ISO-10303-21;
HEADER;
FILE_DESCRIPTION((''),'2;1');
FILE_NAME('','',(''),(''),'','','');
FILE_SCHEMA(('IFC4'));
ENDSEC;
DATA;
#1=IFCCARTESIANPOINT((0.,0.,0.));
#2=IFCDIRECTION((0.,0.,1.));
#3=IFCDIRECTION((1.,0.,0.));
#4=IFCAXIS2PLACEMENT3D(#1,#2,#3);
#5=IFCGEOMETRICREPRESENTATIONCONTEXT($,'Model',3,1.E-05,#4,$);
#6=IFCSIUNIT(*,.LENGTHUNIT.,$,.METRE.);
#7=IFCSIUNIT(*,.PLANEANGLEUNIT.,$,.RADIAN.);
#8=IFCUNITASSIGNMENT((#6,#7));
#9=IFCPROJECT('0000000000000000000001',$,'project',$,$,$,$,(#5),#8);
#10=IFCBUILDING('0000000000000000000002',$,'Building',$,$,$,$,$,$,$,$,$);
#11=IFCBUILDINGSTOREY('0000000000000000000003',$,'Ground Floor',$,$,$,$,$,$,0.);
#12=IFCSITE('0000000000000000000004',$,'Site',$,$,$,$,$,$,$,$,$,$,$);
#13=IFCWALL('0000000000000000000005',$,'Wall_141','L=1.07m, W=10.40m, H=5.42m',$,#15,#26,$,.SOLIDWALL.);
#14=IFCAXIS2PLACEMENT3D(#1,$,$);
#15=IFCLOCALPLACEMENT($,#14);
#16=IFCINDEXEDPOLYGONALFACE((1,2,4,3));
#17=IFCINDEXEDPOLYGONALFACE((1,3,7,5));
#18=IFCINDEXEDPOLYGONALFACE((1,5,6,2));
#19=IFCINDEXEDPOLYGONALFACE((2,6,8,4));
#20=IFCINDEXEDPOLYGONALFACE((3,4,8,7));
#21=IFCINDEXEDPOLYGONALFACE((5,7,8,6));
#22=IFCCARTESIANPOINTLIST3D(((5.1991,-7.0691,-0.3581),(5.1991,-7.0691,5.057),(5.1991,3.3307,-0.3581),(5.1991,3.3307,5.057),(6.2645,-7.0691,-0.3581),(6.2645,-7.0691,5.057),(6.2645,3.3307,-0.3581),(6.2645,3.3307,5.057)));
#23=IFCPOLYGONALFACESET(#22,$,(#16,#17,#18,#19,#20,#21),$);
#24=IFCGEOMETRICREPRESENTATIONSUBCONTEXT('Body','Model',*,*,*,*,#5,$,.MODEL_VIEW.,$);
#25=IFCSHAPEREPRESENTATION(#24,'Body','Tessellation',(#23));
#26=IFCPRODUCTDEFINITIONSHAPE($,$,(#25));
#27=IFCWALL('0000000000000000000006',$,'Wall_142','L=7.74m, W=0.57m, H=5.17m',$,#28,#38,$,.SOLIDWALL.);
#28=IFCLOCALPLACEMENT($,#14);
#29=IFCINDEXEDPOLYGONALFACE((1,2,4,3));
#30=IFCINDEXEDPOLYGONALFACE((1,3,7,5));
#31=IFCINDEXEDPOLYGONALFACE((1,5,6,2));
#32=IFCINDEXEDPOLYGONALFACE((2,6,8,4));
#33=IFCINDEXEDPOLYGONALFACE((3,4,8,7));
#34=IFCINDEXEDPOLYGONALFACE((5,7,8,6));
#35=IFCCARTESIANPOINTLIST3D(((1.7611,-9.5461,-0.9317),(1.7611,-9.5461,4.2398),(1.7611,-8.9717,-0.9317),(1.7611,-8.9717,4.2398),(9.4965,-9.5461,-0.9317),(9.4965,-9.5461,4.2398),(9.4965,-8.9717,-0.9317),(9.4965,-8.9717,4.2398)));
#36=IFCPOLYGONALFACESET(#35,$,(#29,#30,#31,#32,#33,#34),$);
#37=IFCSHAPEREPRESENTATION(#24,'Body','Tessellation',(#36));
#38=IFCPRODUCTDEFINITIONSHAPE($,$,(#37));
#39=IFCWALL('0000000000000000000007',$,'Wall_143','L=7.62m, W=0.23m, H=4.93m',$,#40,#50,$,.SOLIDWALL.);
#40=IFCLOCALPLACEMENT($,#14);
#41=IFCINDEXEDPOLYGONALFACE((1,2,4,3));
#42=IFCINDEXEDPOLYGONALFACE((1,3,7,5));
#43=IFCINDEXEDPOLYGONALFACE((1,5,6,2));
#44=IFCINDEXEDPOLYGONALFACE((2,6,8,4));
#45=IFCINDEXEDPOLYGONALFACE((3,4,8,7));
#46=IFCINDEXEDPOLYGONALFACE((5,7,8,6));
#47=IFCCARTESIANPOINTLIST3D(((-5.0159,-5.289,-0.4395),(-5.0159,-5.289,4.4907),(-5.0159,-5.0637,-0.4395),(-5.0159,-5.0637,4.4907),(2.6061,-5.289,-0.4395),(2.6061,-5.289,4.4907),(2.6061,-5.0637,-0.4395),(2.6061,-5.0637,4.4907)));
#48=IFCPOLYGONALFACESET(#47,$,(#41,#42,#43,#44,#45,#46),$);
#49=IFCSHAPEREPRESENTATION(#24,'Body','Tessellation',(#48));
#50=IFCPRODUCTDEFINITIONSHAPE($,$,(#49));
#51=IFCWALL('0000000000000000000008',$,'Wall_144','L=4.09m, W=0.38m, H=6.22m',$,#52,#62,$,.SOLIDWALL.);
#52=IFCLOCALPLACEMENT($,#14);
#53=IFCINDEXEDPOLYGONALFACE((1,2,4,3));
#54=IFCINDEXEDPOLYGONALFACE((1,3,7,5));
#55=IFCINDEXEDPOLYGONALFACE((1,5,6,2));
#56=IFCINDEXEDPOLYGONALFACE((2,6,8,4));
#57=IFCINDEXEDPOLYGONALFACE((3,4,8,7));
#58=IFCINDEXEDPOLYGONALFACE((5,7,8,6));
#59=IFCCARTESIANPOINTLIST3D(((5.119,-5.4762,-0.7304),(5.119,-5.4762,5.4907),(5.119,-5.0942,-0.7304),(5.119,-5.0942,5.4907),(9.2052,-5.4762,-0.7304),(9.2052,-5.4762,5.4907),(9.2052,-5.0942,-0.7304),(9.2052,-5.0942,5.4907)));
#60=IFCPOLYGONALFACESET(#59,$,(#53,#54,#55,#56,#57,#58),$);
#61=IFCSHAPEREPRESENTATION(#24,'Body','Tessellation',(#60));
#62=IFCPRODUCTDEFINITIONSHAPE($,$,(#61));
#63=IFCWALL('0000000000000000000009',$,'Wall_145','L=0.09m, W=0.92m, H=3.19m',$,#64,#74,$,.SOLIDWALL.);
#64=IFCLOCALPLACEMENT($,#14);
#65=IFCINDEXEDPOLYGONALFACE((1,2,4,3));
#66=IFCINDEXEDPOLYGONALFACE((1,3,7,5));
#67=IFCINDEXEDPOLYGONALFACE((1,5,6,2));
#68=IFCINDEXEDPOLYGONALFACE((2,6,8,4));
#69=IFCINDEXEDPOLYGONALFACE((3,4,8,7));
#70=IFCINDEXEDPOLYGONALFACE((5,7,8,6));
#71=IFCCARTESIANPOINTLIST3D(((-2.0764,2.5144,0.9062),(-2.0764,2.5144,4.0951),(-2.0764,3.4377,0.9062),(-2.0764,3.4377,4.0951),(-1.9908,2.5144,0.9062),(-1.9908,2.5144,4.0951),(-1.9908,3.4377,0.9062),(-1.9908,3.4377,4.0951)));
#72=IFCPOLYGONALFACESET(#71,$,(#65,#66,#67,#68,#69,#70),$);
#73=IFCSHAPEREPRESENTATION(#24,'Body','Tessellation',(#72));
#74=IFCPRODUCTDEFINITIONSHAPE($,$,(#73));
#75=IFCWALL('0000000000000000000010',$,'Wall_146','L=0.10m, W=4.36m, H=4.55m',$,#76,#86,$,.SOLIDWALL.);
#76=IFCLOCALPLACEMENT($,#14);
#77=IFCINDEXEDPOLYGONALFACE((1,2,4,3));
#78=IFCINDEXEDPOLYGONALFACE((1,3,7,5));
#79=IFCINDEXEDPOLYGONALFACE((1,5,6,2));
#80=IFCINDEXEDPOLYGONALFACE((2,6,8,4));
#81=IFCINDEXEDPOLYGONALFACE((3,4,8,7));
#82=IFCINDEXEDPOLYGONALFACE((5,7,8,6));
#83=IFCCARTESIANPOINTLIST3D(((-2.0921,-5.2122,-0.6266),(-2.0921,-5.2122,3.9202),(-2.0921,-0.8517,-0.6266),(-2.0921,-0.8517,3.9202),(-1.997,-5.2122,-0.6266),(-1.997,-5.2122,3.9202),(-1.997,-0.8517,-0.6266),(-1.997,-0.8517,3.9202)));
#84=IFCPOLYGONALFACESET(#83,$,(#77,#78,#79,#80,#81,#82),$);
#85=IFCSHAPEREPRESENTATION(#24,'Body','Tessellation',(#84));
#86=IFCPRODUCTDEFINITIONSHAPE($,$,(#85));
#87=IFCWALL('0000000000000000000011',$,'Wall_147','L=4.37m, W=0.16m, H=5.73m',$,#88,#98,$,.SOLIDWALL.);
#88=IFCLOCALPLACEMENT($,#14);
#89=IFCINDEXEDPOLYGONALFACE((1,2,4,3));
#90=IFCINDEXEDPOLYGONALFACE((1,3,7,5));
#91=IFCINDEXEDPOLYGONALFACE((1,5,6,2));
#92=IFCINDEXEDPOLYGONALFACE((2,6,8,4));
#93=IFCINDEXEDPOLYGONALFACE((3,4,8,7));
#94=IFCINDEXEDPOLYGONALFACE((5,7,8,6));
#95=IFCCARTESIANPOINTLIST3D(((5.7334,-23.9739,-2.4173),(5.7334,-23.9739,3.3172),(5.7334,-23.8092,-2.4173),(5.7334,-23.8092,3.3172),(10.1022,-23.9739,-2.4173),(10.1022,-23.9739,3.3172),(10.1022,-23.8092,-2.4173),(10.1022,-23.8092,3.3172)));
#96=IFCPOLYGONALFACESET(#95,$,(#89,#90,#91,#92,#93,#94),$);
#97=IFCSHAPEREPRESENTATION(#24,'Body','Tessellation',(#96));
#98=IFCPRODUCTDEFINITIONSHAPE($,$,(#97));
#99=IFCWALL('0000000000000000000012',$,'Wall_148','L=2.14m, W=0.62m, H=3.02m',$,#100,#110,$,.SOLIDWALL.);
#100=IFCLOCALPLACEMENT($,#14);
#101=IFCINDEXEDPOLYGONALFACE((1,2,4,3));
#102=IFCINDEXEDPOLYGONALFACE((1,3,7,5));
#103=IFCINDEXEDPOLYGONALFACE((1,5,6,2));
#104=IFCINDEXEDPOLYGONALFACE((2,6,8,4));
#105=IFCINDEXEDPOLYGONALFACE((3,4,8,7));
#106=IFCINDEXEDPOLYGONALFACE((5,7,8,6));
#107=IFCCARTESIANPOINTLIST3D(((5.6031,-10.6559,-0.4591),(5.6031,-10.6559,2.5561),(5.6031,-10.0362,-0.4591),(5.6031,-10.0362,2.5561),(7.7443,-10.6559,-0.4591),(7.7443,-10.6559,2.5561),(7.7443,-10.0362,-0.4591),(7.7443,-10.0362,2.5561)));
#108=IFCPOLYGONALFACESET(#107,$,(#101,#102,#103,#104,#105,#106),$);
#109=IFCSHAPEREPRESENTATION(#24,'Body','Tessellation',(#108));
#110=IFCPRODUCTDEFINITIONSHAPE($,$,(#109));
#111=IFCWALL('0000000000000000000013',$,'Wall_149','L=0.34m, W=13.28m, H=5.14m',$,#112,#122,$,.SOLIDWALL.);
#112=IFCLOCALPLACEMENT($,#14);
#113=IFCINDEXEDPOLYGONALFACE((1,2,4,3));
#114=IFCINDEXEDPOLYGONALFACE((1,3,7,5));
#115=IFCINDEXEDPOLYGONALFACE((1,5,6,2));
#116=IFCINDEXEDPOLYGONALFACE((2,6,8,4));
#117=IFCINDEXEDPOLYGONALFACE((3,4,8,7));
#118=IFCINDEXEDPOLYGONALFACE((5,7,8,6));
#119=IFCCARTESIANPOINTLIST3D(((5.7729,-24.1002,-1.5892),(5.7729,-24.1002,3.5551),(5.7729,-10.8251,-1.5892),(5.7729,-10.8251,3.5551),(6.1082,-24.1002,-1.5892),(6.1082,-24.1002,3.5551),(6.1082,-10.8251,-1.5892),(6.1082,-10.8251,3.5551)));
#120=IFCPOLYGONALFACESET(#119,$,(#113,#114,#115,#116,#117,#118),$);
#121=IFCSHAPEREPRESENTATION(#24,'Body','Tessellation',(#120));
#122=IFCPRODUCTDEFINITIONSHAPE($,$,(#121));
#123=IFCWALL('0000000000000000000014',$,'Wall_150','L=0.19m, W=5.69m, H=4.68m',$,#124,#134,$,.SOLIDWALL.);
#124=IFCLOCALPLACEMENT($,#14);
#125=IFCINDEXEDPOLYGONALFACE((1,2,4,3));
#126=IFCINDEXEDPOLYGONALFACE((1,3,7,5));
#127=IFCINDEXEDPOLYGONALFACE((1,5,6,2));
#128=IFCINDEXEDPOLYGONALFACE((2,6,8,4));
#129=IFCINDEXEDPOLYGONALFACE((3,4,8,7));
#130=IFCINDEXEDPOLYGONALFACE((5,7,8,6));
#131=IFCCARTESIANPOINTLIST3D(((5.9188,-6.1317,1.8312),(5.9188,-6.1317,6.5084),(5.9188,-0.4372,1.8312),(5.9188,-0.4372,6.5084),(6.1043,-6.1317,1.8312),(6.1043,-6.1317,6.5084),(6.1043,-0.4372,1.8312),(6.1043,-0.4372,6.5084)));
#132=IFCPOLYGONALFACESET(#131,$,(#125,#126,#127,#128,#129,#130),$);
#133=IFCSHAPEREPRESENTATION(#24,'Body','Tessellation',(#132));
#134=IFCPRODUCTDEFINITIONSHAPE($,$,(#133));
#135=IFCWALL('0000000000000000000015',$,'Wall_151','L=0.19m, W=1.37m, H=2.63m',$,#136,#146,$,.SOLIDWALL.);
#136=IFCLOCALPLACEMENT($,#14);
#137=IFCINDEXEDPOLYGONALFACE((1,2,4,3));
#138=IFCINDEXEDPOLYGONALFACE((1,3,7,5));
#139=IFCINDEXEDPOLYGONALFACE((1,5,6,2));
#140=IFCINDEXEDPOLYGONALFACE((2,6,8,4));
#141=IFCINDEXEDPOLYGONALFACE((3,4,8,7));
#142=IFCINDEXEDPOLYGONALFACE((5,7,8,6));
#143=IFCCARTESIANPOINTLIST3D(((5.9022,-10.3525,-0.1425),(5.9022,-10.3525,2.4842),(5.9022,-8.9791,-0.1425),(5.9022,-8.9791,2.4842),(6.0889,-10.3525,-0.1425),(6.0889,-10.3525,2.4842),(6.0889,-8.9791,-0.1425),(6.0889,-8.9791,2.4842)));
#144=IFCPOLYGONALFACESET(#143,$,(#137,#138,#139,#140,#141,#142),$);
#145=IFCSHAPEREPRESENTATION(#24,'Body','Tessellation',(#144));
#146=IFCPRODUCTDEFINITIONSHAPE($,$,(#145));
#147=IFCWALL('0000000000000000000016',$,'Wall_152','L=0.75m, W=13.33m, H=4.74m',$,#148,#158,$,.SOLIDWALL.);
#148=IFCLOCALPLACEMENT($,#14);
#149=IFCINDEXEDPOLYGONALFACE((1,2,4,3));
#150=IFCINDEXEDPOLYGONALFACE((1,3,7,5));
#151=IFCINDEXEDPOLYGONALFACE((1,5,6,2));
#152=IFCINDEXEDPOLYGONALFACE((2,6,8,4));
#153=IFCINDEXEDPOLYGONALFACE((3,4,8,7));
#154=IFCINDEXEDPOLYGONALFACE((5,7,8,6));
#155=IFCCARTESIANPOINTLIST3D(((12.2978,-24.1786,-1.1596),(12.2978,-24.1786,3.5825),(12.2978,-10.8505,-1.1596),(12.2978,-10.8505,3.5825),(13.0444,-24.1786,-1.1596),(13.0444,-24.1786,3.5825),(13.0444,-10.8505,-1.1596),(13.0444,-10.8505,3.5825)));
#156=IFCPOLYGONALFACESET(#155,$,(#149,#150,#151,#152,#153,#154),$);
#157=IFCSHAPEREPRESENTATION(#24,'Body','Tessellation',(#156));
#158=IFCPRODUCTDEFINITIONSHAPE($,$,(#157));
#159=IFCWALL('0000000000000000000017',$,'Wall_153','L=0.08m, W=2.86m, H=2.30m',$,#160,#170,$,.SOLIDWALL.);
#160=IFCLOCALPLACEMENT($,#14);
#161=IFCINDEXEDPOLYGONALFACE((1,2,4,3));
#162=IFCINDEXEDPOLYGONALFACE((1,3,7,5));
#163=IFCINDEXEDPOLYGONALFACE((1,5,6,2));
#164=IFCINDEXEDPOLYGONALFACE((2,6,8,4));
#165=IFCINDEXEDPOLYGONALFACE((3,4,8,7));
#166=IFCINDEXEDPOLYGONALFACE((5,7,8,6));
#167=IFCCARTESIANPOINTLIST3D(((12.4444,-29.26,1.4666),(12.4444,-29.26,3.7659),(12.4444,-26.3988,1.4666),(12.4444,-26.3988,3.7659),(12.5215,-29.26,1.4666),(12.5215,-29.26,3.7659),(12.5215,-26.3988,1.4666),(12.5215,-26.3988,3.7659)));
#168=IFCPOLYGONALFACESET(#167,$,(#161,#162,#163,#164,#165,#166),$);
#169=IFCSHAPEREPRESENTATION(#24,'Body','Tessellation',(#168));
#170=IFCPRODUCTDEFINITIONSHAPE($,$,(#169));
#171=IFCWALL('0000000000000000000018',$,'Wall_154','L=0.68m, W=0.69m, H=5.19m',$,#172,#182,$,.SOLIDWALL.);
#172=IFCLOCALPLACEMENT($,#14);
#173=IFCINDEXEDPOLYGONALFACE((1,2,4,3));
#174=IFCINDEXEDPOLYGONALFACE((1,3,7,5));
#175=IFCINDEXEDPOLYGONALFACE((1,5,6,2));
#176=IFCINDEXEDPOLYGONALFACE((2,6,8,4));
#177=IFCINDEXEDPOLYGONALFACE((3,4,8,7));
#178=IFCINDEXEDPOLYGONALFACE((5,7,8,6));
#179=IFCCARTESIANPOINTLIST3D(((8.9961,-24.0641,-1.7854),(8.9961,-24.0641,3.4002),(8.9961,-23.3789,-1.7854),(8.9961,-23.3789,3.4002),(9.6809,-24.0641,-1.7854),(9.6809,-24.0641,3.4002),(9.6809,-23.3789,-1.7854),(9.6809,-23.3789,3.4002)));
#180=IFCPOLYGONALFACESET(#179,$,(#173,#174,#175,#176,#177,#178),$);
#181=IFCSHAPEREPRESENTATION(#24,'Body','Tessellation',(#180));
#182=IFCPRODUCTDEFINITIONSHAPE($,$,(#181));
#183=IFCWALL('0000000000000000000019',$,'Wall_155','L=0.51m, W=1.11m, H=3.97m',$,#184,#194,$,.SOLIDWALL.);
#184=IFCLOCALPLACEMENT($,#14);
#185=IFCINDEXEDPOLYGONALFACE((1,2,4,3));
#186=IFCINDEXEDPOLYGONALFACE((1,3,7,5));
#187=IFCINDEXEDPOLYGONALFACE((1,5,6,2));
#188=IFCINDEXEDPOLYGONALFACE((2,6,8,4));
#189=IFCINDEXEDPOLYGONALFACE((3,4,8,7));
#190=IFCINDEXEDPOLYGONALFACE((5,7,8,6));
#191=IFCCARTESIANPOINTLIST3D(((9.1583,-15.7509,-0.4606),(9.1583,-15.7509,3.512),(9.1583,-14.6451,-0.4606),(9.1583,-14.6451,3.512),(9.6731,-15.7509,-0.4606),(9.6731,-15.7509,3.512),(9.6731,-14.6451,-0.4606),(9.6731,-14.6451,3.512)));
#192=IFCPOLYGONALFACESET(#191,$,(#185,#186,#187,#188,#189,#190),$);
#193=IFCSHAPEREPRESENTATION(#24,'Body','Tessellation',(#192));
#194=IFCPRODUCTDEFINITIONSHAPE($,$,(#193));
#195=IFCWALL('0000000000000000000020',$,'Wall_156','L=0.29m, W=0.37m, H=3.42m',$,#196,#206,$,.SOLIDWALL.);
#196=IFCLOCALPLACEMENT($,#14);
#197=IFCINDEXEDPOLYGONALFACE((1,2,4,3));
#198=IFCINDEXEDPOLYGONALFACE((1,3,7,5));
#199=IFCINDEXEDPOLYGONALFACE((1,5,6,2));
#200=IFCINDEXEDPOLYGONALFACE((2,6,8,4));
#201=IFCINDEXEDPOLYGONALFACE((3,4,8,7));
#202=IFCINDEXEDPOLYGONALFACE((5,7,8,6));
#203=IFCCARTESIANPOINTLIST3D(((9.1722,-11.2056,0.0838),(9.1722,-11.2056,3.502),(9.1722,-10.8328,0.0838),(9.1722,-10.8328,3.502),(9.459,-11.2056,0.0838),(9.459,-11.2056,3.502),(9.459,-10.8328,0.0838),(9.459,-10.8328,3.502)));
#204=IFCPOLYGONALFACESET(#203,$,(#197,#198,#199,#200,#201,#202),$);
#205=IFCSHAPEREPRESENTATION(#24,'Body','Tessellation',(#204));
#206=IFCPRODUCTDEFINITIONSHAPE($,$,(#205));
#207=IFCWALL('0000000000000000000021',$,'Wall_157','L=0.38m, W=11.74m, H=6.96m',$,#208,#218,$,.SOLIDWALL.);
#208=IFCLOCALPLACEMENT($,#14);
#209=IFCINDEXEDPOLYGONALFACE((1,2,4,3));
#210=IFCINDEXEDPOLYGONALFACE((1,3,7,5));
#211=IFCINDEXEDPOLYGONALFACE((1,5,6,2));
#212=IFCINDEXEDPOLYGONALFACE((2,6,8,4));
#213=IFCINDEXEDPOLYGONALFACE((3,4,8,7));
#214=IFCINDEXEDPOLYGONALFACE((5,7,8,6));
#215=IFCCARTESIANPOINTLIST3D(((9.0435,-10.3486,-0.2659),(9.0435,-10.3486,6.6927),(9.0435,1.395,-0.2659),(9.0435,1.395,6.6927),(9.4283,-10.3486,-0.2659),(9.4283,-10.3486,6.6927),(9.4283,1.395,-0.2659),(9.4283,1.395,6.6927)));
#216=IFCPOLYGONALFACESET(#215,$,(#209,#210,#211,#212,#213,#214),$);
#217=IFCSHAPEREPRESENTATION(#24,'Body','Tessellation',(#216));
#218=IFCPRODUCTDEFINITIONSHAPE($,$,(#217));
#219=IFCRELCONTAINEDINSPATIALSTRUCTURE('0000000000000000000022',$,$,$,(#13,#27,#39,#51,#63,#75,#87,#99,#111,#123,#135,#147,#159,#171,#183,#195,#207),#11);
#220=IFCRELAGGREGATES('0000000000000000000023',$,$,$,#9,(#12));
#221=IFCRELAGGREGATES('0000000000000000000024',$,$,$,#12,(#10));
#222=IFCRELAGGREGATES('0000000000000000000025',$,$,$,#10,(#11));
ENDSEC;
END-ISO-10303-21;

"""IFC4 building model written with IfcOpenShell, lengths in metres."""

from ifc_helpers import new_model, si_unit, frame, origin_with_axes, origin_2d, context, subcontext, project, spatial, rectangle, extrude, element, save


model = new_model("IFC4")

# Units and contexts
model_context = context("Model", 3, precision=1e-05, world=origin_with_axes())
body_context = subcontext(model_context, "Body", "Model", "MODEL_VIEW")
ifc_project = project(units=[si_unit("LENGTHUNIT", "METRE"), si_unit("PLANEANGLEUNIT", "RADIAN")], contexts=[model_context])

# Site, building, storey
site = spatial("IfcSite", under=ifc_project, Name="Site")
building = spatial("IfcBuilding", under=site, Name="Building")
storey = spatial("IfcBuildingStorey", under=building, Name="Ground Floor", Elevation=0.0)

# Walls
element("IfcWall", 1, inside=storey, Name="Wall_141", Description="L=1.07m, W=10.40m, H=5.42m", PredefinedType="SOLIDWALL", context=body_context, shape_type="SweptSolid", body=[
    extrude(rectangle(XDim=1.0655, YDim=10.3998, at=origin_2d()), frame((5.7318, -1.8692, -0.3581), z_axis=(0.0, 0.0, 1.0), x_axis=(1.0, 0.0, 0.0)), (0.0, 0.0, 1.0), 5.415),
])
element("IfcWall", 2, inside=storey, Name="Wall_142", Description="L=7.74m, W=0.57m, H=5.17m", PredefinedType="SOLIDWALL", context=body_context, shape_type="SweptSolid", body=[
    extrude(rectangle(XDim=7.7353, YDim=0.5744, at=origin_2d()), frame((5.6288, -9.2589, -0.9317), z_axis=(0.0, 0.0, 1.0), x_axis=(1.0, 0.0, 0.0)), (0.0, 0.0, 1.0), 5.1715),
])
element("IfcWall", 3, inside=storey, Name="Wall_143", Description="L=7.62m, W=0.23m, H=4.93m", PredefinedType="SOLIDWALL", context=body_context, shape_type="SweptSolid", body=[
    extrude(rectangle(XDim=7.622, YDim=0.2253, at=origin_2d()), frame((-1.2049, -5.1763, -0.4395), z_axis=(0.0, 0.0, 1.0), x_axis=(1.0, 0.0, 0.0)), (0.0, 0.0, 1.0), 4.9302),
])
element("IfcWall", 4, inside=storey, Name="Wall_144", Description="L=4.09m, W=0.38m, H=6.22m", PredefinedType="SOLIDWALL", context=body_context, shape_type="SweptSolid", body=[
    extrude(rectangle(XDim=4.0862, YDim=0.382, at=origin_2d()), frame((7.1621, -5.2852, -0.7304), z_axis=(0.0, 0.0, 1.0), x_axis=(1.0, 0.0, 0.0)), (0.0, 0.0, 1.0), 6.221),
])
element("IfcWall", 5, inside=storey, Name="Wall_145", Description="L=0.09m, W=0.92m, H=3.19m", PredefinedType="SOLIDWALL", context=body_context, shape_type="SweptSolid", body=[
    extrude(rectangle(XDim=0.0856, YDim=0.9233, at=origin_2d()), frame((-2.0336, 2.9761, 0.9062), z_axis=(0.0, 0.0, 1.0), x_axis=(1.0, 0.0, 0.0)), (0.0, 0.0, 1.0), 3.1889),
])
element("IfcWall", 6, inside=storey, Name="Wall_146", Description="L=0.10m, W=4.36m, H=4.55m", PredefinedType="SOLIDWALL", context=body_context, shape_type="SweptSolid", body=[
    extrude(rectangle(XDim=0.0952, YDim=4.3605, at=origin_2d()), frame((-2.0445, -3.0319, -0.6266), z_axis=(0.0, 0.0, 1.0), x_axis=(1.0, 0.0, 0.0)), (0.0, 0.0, 1.0), 4.5468),
])
element("IfcWall", 7, inside=storey, Name="Wall_147", Description="L=4.37m, W=0.16m, H=5.73m", PredefinedType="SOLIDWALL", context=body_context, shape_type="SweptSolid", body=[
    extrude(rectangle(XDim=4.3689, YDim=0.1647, at=origin_2d()), frame((7.9178, -23.8915, -2.4173), z_axis=(0.0, 0.0, 1.0), x_axis=(1.0, 0.0, 0.0)), (0.0, 0.0, 1.0), 5.7345),
])
element("IfcWall", 8, inside=storey, Name="Wall_148", Description="L=2.14m, W=0.62m, H=3.02m", PredefinedType="SOLIDWALL", context=body_context, shape_type="SweptSolid", body=[
    extrude(rectangle(XDim=2.1412, YDim=0.6196, at=origin_2d()), frame((6.6737, -10.3461, -0.4591), z_axis=(0.0, 0.0, 1.0), x_axis=(1.0, 0.0, 0.0)), (0.0, 0.0, 1.0), 3.0152),
])
element("IfcWall", 9, inside=storey, Name="Wall_149", Description="L=0.34m, W=13.28m, H=5.14m", PredefinedType="SOLIDWALL", context=body_context, shape_type="SweptSolid", body=[
    extrude(rectangle(XDim=0.3353, YDim=13.2751, at=origin_2d()), frame((5.9405, -17.4627, -1.5892), z_axis=(0.0, 0.0, 1.0), x_axis=(1.0, 0.0, 0.0)), (0.0, 0.0, 1.0), 5.1443),
])
element("IfcWall", 10, inside=storey, Name="Wall_150", Description="L=0.19m, W=5.69m, H=4.68m", PredefinedType="SOLIDWALL", context=body_context, shape_type="SweptSolid", body=[
    extrude(rectangle(XDim=0.1855, YDim=5.6945, at=origin_2d()), frame((6.0116, -3.2845, 1.8312), z_axis=(0.0, 0.0, 1.0), x_axis=(1.0, 0.0, 0.0)), (0.0, 0.0, 1.0), 4.6772),
])
element("IfcWall", 11, inside=storey, Name="Wall_151", Description="L=0.19m, W=1.37m, H=2.63m", PredefinedType="SOLIDWALL", context=body_context, shape_type="SweptSolid", body=[
    extrude(rectangle(XDim=0.1867, YDim=1.3734, at=origin_2d()), frame((5.9956, -9.6658, -0.1425), z_axis=(0.0, 0.0, 1.0), x_axis=(1.0, 0.0, 0.0)), (0.0, 0.0, 1.0), 2.6267),
])
element("IfcWall", 12, inside=storey, Name="Wall_152", Description="L=0.75m, W=13.33m, H=4.74m", PredefinedType="SOLIDWALL", context=body_context, shape_type="SweptSolid", body=[
    extrude(rectangle(XDim=0.7465, YDim=13.3281, at=origin_2d()), frame((12.6711, -17.5145, -1.1596), z_axis=(0.0, 0.0, 1.0), x_axis=(1.0, 0.0, 0.0)), (0.0, 0.0, 1.0), 4.7421),
])
element("IfcWall", 13, inside=storey, Name="Wall_153", Description="L=0.08m, W=2.86m, H=2.30m", PredefinedType="SOLIDWALL", context=body_context, shape_type="SweptSolid", body=[
    extrude(rectangle(XDim=0.0771, YDim=2.8612, at=origin_2d()), frame((12.4829, -27.8294, 1.4666), z_axis=(0.0, 0.0, 1.0), x_axis=(1.0, 0.0, 0.0)), (0.0, 0.0, 1.0), 2.2993),
])
element("IfcWall", 14, inside=storey, Name="Wall_154", Description="L=0.68m, W=0.69m, H=5.19m", PredefinedType="SOLIDWALL", context=body_context, shape_type="SweptSolid", body=[
    extrude(rectangle(XDim=0.6848, YDim=0.6852, at=origin_2d()), frame((9.3385, -23.7215, -1.7854), z_axis=(0.0, 0.0, 1.0), x_axis=(1.0, 0.0, 0.0)), (0.0, 0.0, 1.0), 5.1856),
])
element("IfcWall", 15, inside=storey, Name="Wall_155", Description="L=0.51m, W=1.11m, H=3.97m", PredefinedType="SOLIDWALL", context=body_context, shape_type="SweptSolid", body=[
    extrude(rectangle(XDim=0.5147, YDim=1.1058, at=origin_2d()), frame((9.4157, -15.198, -0.4606), z_axis=(0.0, 0.0, 1.0), x_axis=(1.0, 0.0, 0.0)), (0.0, 0.0, 1.0), 3.9726),
])
element("IfcWall", 16, inside=storey, Name="Wall_156", Description="L=0.29m, W=0.37m, H=3.42m", PredefinedType="SOLIDWALL", context=body_context, shape_type="SweptSolid", body=[
    extrude(rectangle(XDim=0.2869, YDim=0.3728, at=origin_2d()), frame((9.3156, -11.0192, 0.0838), z_axis=(0.0, 0.0, 1.0), x_axis=(1.0, 0.0, 0.0)), (0.0, 0.0, 1.0), 3.4182),
])
element("IfcWall", 17, inside=storey, Name="Wall_157", Description="L=0.38m, W=11.74m, H=6.96m", PredefinedType="SOLIDWALL", context=body_context, shape_type="SweptSolid", body=[
    extrude(rectangle(XDim=0.3848, YDim=11.7436, at=origin_2d()), frame((9.2359, -4.4768, -0.2659), z_axis=(0.0, 0.0, 1.0), x_axis=(1.0, 0.0, 0.0)), (0.0, 0.0, 1.0), 6.9586),
])

save(model, "model.ifc")
